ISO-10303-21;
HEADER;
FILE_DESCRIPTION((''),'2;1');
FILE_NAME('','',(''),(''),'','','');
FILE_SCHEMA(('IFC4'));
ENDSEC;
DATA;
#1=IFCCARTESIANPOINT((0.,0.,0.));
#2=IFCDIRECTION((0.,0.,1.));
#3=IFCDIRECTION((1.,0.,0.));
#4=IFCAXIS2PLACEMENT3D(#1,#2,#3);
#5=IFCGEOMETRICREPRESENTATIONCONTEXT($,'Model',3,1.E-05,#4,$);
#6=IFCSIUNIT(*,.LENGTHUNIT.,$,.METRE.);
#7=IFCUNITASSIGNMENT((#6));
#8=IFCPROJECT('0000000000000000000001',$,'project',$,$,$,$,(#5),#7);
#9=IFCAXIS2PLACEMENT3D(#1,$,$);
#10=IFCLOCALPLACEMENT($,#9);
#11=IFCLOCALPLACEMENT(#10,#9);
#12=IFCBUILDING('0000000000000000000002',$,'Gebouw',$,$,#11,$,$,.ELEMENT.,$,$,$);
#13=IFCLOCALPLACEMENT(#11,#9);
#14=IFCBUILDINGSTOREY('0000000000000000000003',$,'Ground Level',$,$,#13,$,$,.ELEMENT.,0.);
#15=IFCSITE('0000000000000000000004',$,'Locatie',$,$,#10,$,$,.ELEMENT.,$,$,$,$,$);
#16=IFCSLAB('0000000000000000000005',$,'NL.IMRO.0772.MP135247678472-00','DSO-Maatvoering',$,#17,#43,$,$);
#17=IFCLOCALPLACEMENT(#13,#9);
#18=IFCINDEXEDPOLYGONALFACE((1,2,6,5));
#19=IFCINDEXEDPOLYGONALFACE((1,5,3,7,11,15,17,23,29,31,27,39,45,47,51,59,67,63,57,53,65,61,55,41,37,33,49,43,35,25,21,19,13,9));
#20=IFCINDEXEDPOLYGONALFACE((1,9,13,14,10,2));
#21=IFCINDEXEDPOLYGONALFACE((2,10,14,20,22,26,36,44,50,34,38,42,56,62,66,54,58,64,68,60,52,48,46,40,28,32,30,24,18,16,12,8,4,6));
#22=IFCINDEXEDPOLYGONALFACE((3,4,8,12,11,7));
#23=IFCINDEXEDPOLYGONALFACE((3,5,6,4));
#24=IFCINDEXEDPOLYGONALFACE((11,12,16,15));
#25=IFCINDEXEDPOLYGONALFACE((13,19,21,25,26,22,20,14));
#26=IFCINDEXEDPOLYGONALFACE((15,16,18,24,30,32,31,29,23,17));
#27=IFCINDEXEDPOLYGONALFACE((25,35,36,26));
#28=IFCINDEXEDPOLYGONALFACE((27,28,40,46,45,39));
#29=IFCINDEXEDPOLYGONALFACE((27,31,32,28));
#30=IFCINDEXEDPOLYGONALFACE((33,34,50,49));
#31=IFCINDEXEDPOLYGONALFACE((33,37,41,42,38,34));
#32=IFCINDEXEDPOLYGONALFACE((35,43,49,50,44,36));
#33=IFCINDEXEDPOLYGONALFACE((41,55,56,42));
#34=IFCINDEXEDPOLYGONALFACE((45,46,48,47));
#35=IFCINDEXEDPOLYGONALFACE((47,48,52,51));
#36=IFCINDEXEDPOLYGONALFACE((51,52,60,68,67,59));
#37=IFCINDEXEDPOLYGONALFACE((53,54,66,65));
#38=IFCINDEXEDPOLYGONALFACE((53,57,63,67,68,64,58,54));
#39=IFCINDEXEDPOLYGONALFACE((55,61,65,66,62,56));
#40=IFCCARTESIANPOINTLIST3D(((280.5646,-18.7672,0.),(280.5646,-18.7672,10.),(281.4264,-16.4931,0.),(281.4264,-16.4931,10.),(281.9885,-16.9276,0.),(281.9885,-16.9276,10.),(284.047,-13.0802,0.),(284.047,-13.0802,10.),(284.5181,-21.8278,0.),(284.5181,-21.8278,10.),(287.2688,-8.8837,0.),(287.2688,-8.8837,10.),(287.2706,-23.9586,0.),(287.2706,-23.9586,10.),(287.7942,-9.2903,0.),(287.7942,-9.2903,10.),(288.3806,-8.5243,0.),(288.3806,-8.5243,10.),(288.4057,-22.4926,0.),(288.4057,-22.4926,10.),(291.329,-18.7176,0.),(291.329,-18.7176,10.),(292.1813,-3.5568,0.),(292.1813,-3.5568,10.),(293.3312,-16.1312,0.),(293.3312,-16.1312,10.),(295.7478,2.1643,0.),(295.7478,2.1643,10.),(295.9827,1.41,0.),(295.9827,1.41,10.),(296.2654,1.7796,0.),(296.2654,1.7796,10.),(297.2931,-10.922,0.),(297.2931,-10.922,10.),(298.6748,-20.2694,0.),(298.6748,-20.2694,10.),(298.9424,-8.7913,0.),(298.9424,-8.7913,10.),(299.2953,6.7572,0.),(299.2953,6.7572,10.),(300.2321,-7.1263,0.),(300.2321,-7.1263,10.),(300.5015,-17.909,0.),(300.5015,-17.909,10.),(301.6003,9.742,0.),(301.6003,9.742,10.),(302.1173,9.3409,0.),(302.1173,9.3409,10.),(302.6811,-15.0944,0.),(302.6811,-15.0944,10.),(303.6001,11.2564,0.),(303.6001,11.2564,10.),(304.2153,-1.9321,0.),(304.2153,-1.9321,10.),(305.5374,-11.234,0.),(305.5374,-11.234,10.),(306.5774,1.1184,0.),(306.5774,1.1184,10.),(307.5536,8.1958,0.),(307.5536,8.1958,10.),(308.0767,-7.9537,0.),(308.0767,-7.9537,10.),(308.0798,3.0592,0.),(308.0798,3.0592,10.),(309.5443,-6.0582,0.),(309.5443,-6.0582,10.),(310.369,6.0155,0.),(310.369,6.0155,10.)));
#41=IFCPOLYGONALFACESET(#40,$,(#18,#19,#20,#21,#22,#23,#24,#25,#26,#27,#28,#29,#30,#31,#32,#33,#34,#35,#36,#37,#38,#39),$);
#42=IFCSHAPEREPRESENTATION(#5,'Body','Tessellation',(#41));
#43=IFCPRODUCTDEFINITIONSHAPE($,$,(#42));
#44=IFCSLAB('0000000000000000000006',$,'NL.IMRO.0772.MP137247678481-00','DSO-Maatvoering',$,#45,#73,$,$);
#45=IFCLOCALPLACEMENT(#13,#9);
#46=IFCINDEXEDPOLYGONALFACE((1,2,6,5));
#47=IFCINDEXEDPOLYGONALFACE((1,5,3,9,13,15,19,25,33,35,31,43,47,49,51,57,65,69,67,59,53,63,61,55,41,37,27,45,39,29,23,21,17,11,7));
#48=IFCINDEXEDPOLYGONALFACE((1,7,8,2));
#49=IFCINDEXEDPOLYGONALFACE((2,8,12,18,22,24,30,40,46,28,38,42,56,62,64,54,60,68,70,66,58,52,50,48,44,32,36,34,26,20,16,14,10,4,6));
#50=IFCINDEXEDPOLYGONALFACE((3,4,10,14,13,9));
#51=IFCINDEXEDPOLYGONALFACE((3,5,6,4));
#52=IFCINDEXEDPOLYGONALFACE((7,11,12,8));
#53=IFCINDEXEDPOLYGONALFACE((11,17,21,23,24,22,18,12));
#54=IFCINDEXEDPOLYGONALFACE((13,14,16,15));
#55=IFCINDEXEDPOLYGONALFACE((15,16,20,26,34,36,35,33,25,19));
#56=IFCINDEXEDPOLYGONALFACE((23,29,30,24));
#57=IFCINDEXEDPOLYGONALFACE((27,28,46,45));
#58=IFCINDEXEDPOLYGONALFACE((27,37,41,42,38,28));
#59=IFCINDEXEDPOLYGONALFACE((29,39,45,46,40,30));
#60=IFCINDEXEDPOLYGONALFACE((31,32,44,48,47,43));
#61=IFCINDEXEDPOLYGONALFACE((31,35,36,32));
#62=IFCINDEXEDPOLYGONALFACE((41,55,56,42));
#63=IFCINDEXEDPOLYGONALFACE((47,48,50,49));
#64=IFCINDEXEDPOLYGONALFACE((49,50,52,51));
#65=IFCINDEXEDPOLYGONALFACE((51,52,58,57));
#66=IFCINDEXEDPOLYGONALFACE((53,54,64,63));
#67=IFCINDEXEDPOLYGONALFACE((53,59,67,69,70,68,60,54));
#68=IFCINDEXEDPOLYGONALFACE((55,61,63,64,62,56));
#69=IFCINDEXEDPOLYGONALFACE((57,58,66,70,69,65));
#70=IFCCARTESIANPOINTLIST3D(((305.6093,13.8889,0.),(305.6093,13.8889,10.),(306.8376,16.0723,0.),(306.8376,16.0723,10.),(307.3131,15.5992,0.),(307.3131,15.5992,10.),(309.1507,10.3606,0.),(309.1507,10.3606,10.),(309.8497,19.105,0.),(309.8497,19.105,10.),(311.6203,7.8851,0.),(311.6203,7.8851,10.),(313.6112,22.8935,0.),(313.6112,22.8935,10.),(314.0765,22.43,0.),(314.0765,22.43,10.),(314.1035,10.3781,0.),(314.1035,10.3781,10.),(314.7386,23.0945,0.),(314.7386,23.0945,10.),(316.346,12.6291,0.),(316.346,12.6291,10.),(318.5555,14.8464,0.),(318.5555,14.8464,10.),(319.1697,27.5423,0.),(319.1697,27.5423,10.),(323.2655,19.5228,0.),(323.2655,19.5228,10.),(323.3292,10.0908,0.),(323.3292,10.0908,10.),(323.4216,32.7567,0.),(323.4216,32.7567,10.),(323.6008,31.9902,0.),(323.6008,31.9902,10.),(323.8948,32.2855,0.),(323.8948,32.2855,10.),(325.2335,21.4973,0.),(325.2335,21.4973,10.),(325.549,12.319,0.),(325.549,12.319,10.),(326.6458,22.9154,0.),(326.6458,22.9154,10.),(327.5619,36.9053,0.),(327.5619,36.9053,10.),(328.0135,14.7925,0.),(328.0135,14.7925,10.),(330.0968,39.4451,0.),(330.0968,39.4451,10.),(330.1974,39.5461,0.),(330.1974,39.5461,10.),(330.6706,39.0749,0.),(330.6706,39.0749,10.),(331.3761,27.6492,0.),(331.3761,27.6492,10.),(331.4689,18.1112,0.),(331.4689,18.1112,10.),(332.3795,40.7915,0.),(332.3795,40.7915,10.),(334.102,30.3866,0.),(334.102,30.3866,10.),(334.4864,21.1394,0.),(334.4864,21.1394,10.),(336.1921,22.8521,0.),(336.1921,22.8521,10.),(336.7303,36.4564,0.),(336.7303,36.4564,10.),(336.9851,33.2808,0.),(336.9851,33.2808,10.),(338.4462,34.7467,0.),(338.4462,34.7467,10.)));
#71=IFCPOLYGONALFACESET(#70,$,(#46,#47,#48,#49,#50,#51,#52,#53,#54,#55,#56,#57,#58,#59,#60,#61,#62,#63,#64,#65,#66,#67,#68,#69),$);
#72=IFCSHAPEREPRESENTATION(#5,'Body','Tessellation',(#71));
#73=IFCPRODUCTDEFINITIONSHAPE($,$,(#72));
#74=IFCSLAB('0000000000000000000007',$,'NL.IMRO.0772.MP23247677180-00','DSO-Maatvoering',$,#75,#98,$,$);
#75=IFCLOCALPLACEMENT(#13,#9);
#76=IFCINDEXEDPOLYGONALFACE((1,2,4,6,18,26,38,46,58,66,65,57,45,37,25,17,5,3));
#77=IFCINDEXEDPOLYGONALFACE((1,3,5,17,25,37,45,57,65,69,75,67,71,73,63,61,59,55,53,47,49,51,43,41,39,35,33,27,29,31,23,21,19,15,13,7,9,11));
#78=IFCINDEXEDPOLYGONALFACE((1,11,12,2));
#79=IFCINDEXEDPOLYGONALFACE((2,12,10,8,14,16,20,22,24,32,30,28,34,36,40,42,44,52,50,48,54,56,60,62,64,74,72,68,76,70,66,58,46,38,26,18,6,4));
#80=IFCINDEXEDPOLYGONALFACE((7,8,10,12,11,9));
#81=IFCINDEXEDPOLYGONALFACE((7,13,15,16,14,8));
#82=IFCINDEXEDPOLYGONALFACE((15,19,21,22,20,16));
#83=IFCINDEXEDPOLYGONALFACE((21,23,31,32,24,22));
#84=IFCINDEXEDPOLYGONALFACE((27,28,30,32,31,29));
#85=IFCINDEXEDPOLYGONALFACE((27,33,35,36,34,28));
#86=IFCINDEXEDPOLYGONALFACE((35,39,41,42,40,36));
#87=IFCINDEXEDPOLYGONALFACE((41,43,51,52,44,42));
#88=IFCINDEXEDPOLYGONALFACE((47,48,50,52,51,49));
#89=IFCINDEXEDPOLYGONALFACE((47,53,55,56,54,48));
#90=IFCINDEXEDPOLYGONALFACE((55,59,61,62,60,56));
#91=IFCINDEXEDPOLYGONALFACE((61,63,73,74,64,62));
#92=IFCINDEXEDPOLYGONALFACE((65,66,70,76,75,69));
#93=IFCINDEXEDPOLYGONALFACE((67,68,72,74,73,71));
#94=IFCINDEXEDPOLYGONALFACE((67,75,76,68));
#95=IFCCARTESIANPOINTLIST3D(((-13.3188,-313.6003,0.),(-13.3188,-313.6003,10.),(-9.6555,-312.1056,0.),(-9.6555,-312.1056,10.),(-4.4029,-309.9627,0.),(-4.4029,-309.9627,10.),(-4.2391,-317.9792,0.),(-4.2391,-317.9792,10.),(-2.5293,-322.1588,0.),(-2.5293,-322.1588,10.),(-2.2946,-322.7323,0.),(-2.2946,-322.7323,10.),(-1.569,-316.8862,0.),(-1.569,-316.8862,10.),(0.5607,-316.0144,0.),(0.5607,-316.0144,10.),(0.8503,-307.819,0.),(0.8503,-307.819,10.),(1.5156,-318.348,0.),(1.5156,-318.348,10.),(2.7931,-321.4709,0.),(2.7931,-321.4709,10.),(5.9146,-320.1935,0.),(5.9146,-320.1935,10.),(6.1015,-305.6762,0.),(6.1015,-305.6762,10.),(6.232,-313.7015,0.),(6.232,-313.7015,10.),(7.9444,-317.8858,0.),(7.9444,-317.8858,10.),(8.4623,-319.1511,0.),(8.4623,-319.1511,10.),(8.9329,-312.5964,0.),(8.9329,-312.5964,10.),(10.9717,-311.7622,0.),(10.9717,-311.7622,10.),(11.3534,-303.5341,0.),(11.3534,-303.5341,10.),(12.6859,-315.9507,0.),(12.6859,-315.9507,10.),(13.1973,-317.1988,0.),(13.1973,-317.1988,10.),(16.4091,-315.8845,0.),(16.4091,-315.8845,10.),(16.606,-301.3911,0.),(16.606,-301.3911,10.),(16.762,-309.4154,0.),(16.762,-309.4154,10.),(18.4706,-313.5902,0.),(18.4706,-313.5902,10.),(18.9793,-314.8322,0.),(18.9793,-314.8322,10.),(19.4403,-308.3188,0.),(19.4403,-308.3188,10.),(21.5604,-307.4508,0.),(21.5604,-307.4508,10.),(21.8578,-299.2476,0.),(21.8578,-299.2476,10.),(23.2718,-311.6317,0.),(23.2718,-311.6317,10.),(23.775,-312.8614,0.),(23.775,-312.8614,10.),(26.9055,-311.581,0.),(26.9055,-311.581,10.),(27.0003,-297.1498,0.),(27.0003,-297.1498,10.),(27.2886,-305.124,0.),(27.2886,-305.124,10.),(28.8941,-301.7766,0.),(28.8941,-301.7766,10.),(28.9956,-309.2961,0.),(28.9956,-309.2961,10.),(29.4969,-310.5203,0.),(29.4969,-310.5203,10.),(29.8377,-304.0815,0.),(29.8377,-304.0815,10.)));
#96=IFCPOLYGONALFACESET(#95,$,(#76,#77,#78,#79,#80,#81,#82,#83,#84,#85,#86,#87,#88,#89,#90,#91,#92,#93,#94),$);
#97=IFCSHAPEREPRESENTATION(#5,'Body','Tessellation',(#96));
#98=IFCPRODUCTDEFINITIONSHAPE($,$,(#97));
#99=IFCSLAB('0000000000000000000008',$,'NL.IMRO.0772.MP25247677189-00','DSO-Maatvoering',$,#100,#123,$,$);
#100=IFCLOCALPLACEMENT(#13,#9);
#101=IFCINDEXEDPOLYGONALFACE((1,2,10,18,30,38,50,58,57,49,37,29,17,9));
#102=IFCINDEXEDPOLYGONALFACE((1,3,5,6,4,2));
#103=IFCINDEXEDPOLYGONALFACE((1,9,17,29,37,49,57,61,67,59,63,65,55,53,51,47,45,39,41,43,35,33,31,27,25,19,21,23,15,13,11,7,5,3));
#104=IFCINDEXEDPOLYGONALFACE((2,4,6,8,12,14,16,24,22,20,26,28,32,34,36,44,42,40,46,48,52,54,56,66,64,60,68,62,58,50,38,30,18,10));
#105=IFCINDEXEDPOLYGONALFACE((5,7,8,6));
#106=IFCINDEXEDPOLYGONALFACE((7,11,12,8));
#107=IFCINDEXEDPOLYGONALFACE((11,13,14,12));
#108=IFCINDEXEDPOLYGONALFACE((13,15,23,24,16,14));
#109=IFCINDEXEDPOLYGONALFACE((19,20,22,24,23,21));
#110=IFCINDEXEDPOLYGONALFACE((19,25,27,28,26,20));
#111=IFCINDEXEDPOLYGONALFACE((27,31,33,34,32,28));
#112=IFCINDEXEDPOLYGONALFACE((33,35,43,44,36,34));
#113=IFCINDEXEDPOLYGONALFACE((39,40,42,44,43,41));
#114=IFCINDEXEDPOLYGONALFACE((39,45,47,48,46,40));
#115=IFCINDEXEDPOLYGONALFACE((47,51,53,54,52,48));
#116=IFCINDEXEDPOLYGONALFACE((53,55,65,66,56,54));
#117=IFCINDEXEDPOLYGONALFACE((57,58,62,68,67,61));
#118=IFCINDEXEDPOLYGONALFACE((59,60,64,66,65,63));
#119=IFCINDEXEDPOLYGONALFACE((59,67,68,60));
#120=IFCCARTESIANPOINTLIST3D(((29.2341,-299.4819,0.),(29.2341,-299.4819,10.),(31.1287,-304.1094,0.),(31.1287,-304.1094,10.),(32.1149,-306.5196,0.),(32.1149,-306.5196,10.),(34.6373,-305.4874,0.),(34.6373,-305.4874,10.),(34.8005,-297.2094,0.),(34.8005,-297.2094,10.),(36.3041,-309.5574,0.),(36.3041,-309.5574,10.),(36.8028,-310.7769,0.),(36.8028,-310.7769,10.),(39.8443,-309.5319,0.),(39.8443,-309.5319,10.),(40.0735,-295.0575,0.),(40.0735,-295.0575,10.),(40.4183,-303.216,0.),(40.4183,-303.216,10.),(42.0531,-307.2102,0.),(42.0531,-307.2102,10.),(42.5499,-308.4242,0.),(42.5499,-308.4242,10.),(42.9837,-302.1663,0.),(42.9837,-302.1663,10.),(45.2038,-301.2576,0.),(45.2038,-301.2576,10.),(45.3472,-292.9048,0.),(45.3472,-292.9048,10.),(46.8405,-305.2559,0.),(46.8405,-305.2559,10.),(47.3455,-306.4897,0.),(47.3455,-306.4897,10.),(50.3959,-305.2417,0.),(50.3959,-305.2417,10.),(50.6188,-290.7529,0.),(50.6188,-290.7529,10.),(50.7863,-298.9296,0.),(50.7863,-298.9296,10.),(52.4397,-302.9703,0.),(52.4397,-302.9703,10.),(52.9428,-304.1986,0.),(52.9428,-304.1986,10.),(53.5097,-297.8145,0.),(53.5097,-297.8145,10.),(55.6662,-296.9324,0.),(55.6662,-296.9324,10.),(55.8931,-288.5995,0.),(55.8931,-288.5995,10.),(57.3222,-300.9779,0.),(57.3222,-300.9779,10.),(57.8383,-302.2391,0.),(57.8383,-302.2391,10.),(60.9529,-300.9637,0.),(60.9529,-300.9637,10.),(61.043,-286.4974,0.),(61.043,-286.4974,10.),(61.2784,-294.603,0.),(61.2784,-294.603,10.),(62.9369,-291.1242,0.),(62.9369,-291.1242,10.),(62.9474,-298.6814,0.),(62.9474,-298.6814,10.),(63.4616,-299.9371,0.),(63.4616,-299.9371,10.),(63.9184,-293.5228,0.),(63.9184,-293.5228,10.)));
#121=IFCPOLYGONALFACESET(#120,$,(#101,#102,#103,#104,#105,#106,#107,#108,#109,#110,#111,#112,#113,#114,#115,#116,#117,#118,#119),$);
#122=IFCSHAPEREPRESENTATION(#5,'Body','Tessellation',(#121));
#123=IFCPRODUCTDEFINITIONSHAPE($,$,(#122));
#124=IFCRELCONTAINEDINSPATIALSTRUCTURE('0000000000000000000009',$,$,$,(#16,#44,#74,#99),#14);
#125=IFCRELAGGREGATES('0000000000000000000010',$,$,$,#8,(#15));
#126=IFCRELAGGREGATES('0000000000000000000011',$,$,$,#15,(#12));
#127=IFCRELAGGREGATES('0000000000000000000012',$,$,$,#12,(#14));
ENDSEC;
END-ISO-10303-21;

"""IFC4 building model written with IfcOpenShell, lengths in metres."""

from ifc_helpers import new_model, si_unit, origin, origin_with_axes, place, context, project, spatial, polyline, outline, extrude, element, save


model = new_model("IFC4")

# Units and contexts
model_context = context("Model", 3, precision=1e-05, world=origin_with_axes())
ifc_project = project(units=[si_unit("LENGTHUNIT", "METRE")], contexts=[model_context])

# Site, building, storey
site_placement = place(None, origin())
site = spatial("IfcSite", under=ifc_project, at=site_placement, Name="Locatie", CompositionType="ELEMENT")
building_placement = place(site_placement, origin())
building = spatial("IfcBuilding", under=site, at=building_placement, Name="Gebouw", CompositionType="ELEMENT")
storey_placement = place(building_placement, origin())
storey = spatial("IfcBuildingStorey", under=building, at=storey_placement, Name="Ground Level", CompositionType="ELEMENT", Elevation=0.0)

# Slabs
slab_1_placement = place(storey_placement, origin())
element("IfcSlab", 1, at=slab_1_placement, inside=storey, Name="NL.IMRO.0772.MP135247678472-00", Description="DSO-Maatvoering", context=model_context, shape_type="SweptSolid", body=[
    extrude(outline(polyline([(287.2706, -23.9586), (284.5181, -21.8278), (280.5646, -18.7672), (281.9885, -16.9276), (281.4264, -16.4931), (284.047, -13.0802), (287.2688, -8.8837), (287.7942, -9.2903), (288.3806, -8.5243), (292.1813, -3.5568), (295.9827, 1.41), (296.2654, 1.7796), (295.7478, 2.1643), (299.2953, 6.7572), (301.6003, 9.742), (302.1173, 9.3409), (303.6001, 11.2564), (307.5536, 8.1958), (310.369, 6.0155), (308.0798, 3.0592), (306.5774, 1.1184), (304.2153, -1.9321), (309.5443, -6.0582), (308.0767, -7.9537), (305.5374, -11.234), (300.2321, -7.1263), (298.9424, -8.7913), (297.2931, -10.922), (302.6811, -15.0944), (300.5015, -17.909), (298.6748, -20.2694), (293.3312, -16.1312), (291.329, -18.7176), (288.4057, -22.4926), (287.2706, -23.9586)])), origin_with_axes(), (0.0, 0.0, 1.0), 10.0),
])
slab_2_placement = place(storey_placement, origin())
element("IfcSlab", 2, at=slab_2_placement, inside=storey, Name="NL.IMRO.0772.MP137247678481-00", Description="DSO-Maatvoering", context=model_context, shape_type="SweptSolid", body=[
    extrude(outline(polyline([(330.6706, 39.0749), (332.3795, 40.7915), (336.7303, 36.4564), (338.4462, 34.7467), (336.9851, 33.2808), (334.102, 30.3866), (331.3761, 27.6492), (336.1921, 22.8521), (334.4864, 21.1394), (331.4689, 18.1112), (326.6458, 22.9154), (325.2335, 21.4973), (323.2655, 19.5228), (328.0135, 14.7925), (325.549, 12.319), (323.3292, 10.0908), (318.5555, 14.8464), (316.346, 12.6291), (314.1035, 10.3781), (311.6203, 7.8851), (309.1507, 10.3606), (305.6093, 13.8889), (307.3131, 15.5992), (306.8376, 16.0723), (309.8497, 19.105), (313.6112, 22.8935), (314.0765, 22.43), (314.7386, 23.0945), (319.1697, 27.5423), (323.6008, 31.9902), (323.8948, 32.2855), (323.4216, 32.7567), (327.5619, 36.9053), (330.0968, 39.4451), (330.1974, 39.5461), (330.6706, 39.0749)])), origin_with_axes(), (0.0, 0.0, 1.0), 10.0),
])
slab_3_placement = place(storey_placement, origin())
element("IfcSlab", 3, at=slab_3_placement, inside=storey, Name="NL.IMRO.0772.MP23247677180-00", Description="DSO-Maatvoering", context=model_context, shape_type="SweptSolid", body=[
    extrude(outline(polyline([(-9.6555, -312.1056), (-4.4029, -309.9627), (0.8503, -307.819), (6.1015, -305.6762), (11.3534, -303.5341), (16.606, -301.3911), (21.8578, -299.2476), (27.0003, -297.1498), (28.8941, -301.7766), (29.8377, -304.0815), (27.2886, -305.124), (28.9956, -309.2961), (29.4969, -310.5203), (26.9055, -311.581), (23.775, -312.8614), (23.2718, -311.6317), (21.5604, -307.4508), (19.4403, -308.3188), (16.762, -309.4154), (18.4706, -313.5902), (18.9793, -314.8322), (16.4091, -315.8845), (13.1973, -317.1988), (12.6859, -315.9507), (10.9717, -311.7622), (8.9329, -312.5964), (6.232, -313.7015), (7.9444, -317.8858), (8.4623, -319.1511), (5.9146, -320.1935), (2.7931, -321.4709), (1.5156, -318.348), (0.5607, -316.0144), (-1.569, -316.8862), (-4.2391, -317.9792), (-2.5293, -322.1588), (-2.2946, -322.7323), (-13.3188, -313.6003), (-9.6555, -312.1056)])), origin_with_axes(), (0.0, 0.0, 1.0), 10.0),
])
slab_4_placement = place(storey_placement, origin())
element("IfcSlab", 4, at=slab_4_placement, inside=storey, Name="NL.IMRO.0772.MP25247677189-00", Description="DSO-Maatvoering", context=model_context, shape_type="SweptSolid", body=[
    extrude(outline(polyline([(61.2784, -294.603), (62.9474, -298.6814), (63.4616, -299.9371), (60.9529, -300.9637), (57.8383, -302.2391), (57.3222, -300.9779), (55.6662, -296.9324), (53.5097, -297.8145), (50.7863, -298.9296), (52.4397, -302.9703), (52.9428, -304.1986), (50.3959, -305.2417), (47.3455, -306.4897), (46.8405, -305.2559), (45.2038, -301.2576), (42.9837, -302.1663), (40.4183, -303.216), (42.0531, -307.2102), (42.5499, -308.4242), (39.8443, -309.5319), (36.8028, -310.7769), (36.3041, -309.5574), (34.6373, -305.4874), (32.1149, -306.5196), (31.1287, -304.1094), (29.2341, -299.4819), (34.8005, -297.2094), (40.0735, -295.0575), (45.3472, -292.9048), (50.6188, -290.7529), (55.8931, -288.5995), (61.043, -286.4974), (62.9369, -291.1242), (63.9184, -293.5228), (61.2784, -294.603)])), origin_with_axes(), (0.0, 0.0, 1.0), 10.0),
])

save(model, "model.ifc")
